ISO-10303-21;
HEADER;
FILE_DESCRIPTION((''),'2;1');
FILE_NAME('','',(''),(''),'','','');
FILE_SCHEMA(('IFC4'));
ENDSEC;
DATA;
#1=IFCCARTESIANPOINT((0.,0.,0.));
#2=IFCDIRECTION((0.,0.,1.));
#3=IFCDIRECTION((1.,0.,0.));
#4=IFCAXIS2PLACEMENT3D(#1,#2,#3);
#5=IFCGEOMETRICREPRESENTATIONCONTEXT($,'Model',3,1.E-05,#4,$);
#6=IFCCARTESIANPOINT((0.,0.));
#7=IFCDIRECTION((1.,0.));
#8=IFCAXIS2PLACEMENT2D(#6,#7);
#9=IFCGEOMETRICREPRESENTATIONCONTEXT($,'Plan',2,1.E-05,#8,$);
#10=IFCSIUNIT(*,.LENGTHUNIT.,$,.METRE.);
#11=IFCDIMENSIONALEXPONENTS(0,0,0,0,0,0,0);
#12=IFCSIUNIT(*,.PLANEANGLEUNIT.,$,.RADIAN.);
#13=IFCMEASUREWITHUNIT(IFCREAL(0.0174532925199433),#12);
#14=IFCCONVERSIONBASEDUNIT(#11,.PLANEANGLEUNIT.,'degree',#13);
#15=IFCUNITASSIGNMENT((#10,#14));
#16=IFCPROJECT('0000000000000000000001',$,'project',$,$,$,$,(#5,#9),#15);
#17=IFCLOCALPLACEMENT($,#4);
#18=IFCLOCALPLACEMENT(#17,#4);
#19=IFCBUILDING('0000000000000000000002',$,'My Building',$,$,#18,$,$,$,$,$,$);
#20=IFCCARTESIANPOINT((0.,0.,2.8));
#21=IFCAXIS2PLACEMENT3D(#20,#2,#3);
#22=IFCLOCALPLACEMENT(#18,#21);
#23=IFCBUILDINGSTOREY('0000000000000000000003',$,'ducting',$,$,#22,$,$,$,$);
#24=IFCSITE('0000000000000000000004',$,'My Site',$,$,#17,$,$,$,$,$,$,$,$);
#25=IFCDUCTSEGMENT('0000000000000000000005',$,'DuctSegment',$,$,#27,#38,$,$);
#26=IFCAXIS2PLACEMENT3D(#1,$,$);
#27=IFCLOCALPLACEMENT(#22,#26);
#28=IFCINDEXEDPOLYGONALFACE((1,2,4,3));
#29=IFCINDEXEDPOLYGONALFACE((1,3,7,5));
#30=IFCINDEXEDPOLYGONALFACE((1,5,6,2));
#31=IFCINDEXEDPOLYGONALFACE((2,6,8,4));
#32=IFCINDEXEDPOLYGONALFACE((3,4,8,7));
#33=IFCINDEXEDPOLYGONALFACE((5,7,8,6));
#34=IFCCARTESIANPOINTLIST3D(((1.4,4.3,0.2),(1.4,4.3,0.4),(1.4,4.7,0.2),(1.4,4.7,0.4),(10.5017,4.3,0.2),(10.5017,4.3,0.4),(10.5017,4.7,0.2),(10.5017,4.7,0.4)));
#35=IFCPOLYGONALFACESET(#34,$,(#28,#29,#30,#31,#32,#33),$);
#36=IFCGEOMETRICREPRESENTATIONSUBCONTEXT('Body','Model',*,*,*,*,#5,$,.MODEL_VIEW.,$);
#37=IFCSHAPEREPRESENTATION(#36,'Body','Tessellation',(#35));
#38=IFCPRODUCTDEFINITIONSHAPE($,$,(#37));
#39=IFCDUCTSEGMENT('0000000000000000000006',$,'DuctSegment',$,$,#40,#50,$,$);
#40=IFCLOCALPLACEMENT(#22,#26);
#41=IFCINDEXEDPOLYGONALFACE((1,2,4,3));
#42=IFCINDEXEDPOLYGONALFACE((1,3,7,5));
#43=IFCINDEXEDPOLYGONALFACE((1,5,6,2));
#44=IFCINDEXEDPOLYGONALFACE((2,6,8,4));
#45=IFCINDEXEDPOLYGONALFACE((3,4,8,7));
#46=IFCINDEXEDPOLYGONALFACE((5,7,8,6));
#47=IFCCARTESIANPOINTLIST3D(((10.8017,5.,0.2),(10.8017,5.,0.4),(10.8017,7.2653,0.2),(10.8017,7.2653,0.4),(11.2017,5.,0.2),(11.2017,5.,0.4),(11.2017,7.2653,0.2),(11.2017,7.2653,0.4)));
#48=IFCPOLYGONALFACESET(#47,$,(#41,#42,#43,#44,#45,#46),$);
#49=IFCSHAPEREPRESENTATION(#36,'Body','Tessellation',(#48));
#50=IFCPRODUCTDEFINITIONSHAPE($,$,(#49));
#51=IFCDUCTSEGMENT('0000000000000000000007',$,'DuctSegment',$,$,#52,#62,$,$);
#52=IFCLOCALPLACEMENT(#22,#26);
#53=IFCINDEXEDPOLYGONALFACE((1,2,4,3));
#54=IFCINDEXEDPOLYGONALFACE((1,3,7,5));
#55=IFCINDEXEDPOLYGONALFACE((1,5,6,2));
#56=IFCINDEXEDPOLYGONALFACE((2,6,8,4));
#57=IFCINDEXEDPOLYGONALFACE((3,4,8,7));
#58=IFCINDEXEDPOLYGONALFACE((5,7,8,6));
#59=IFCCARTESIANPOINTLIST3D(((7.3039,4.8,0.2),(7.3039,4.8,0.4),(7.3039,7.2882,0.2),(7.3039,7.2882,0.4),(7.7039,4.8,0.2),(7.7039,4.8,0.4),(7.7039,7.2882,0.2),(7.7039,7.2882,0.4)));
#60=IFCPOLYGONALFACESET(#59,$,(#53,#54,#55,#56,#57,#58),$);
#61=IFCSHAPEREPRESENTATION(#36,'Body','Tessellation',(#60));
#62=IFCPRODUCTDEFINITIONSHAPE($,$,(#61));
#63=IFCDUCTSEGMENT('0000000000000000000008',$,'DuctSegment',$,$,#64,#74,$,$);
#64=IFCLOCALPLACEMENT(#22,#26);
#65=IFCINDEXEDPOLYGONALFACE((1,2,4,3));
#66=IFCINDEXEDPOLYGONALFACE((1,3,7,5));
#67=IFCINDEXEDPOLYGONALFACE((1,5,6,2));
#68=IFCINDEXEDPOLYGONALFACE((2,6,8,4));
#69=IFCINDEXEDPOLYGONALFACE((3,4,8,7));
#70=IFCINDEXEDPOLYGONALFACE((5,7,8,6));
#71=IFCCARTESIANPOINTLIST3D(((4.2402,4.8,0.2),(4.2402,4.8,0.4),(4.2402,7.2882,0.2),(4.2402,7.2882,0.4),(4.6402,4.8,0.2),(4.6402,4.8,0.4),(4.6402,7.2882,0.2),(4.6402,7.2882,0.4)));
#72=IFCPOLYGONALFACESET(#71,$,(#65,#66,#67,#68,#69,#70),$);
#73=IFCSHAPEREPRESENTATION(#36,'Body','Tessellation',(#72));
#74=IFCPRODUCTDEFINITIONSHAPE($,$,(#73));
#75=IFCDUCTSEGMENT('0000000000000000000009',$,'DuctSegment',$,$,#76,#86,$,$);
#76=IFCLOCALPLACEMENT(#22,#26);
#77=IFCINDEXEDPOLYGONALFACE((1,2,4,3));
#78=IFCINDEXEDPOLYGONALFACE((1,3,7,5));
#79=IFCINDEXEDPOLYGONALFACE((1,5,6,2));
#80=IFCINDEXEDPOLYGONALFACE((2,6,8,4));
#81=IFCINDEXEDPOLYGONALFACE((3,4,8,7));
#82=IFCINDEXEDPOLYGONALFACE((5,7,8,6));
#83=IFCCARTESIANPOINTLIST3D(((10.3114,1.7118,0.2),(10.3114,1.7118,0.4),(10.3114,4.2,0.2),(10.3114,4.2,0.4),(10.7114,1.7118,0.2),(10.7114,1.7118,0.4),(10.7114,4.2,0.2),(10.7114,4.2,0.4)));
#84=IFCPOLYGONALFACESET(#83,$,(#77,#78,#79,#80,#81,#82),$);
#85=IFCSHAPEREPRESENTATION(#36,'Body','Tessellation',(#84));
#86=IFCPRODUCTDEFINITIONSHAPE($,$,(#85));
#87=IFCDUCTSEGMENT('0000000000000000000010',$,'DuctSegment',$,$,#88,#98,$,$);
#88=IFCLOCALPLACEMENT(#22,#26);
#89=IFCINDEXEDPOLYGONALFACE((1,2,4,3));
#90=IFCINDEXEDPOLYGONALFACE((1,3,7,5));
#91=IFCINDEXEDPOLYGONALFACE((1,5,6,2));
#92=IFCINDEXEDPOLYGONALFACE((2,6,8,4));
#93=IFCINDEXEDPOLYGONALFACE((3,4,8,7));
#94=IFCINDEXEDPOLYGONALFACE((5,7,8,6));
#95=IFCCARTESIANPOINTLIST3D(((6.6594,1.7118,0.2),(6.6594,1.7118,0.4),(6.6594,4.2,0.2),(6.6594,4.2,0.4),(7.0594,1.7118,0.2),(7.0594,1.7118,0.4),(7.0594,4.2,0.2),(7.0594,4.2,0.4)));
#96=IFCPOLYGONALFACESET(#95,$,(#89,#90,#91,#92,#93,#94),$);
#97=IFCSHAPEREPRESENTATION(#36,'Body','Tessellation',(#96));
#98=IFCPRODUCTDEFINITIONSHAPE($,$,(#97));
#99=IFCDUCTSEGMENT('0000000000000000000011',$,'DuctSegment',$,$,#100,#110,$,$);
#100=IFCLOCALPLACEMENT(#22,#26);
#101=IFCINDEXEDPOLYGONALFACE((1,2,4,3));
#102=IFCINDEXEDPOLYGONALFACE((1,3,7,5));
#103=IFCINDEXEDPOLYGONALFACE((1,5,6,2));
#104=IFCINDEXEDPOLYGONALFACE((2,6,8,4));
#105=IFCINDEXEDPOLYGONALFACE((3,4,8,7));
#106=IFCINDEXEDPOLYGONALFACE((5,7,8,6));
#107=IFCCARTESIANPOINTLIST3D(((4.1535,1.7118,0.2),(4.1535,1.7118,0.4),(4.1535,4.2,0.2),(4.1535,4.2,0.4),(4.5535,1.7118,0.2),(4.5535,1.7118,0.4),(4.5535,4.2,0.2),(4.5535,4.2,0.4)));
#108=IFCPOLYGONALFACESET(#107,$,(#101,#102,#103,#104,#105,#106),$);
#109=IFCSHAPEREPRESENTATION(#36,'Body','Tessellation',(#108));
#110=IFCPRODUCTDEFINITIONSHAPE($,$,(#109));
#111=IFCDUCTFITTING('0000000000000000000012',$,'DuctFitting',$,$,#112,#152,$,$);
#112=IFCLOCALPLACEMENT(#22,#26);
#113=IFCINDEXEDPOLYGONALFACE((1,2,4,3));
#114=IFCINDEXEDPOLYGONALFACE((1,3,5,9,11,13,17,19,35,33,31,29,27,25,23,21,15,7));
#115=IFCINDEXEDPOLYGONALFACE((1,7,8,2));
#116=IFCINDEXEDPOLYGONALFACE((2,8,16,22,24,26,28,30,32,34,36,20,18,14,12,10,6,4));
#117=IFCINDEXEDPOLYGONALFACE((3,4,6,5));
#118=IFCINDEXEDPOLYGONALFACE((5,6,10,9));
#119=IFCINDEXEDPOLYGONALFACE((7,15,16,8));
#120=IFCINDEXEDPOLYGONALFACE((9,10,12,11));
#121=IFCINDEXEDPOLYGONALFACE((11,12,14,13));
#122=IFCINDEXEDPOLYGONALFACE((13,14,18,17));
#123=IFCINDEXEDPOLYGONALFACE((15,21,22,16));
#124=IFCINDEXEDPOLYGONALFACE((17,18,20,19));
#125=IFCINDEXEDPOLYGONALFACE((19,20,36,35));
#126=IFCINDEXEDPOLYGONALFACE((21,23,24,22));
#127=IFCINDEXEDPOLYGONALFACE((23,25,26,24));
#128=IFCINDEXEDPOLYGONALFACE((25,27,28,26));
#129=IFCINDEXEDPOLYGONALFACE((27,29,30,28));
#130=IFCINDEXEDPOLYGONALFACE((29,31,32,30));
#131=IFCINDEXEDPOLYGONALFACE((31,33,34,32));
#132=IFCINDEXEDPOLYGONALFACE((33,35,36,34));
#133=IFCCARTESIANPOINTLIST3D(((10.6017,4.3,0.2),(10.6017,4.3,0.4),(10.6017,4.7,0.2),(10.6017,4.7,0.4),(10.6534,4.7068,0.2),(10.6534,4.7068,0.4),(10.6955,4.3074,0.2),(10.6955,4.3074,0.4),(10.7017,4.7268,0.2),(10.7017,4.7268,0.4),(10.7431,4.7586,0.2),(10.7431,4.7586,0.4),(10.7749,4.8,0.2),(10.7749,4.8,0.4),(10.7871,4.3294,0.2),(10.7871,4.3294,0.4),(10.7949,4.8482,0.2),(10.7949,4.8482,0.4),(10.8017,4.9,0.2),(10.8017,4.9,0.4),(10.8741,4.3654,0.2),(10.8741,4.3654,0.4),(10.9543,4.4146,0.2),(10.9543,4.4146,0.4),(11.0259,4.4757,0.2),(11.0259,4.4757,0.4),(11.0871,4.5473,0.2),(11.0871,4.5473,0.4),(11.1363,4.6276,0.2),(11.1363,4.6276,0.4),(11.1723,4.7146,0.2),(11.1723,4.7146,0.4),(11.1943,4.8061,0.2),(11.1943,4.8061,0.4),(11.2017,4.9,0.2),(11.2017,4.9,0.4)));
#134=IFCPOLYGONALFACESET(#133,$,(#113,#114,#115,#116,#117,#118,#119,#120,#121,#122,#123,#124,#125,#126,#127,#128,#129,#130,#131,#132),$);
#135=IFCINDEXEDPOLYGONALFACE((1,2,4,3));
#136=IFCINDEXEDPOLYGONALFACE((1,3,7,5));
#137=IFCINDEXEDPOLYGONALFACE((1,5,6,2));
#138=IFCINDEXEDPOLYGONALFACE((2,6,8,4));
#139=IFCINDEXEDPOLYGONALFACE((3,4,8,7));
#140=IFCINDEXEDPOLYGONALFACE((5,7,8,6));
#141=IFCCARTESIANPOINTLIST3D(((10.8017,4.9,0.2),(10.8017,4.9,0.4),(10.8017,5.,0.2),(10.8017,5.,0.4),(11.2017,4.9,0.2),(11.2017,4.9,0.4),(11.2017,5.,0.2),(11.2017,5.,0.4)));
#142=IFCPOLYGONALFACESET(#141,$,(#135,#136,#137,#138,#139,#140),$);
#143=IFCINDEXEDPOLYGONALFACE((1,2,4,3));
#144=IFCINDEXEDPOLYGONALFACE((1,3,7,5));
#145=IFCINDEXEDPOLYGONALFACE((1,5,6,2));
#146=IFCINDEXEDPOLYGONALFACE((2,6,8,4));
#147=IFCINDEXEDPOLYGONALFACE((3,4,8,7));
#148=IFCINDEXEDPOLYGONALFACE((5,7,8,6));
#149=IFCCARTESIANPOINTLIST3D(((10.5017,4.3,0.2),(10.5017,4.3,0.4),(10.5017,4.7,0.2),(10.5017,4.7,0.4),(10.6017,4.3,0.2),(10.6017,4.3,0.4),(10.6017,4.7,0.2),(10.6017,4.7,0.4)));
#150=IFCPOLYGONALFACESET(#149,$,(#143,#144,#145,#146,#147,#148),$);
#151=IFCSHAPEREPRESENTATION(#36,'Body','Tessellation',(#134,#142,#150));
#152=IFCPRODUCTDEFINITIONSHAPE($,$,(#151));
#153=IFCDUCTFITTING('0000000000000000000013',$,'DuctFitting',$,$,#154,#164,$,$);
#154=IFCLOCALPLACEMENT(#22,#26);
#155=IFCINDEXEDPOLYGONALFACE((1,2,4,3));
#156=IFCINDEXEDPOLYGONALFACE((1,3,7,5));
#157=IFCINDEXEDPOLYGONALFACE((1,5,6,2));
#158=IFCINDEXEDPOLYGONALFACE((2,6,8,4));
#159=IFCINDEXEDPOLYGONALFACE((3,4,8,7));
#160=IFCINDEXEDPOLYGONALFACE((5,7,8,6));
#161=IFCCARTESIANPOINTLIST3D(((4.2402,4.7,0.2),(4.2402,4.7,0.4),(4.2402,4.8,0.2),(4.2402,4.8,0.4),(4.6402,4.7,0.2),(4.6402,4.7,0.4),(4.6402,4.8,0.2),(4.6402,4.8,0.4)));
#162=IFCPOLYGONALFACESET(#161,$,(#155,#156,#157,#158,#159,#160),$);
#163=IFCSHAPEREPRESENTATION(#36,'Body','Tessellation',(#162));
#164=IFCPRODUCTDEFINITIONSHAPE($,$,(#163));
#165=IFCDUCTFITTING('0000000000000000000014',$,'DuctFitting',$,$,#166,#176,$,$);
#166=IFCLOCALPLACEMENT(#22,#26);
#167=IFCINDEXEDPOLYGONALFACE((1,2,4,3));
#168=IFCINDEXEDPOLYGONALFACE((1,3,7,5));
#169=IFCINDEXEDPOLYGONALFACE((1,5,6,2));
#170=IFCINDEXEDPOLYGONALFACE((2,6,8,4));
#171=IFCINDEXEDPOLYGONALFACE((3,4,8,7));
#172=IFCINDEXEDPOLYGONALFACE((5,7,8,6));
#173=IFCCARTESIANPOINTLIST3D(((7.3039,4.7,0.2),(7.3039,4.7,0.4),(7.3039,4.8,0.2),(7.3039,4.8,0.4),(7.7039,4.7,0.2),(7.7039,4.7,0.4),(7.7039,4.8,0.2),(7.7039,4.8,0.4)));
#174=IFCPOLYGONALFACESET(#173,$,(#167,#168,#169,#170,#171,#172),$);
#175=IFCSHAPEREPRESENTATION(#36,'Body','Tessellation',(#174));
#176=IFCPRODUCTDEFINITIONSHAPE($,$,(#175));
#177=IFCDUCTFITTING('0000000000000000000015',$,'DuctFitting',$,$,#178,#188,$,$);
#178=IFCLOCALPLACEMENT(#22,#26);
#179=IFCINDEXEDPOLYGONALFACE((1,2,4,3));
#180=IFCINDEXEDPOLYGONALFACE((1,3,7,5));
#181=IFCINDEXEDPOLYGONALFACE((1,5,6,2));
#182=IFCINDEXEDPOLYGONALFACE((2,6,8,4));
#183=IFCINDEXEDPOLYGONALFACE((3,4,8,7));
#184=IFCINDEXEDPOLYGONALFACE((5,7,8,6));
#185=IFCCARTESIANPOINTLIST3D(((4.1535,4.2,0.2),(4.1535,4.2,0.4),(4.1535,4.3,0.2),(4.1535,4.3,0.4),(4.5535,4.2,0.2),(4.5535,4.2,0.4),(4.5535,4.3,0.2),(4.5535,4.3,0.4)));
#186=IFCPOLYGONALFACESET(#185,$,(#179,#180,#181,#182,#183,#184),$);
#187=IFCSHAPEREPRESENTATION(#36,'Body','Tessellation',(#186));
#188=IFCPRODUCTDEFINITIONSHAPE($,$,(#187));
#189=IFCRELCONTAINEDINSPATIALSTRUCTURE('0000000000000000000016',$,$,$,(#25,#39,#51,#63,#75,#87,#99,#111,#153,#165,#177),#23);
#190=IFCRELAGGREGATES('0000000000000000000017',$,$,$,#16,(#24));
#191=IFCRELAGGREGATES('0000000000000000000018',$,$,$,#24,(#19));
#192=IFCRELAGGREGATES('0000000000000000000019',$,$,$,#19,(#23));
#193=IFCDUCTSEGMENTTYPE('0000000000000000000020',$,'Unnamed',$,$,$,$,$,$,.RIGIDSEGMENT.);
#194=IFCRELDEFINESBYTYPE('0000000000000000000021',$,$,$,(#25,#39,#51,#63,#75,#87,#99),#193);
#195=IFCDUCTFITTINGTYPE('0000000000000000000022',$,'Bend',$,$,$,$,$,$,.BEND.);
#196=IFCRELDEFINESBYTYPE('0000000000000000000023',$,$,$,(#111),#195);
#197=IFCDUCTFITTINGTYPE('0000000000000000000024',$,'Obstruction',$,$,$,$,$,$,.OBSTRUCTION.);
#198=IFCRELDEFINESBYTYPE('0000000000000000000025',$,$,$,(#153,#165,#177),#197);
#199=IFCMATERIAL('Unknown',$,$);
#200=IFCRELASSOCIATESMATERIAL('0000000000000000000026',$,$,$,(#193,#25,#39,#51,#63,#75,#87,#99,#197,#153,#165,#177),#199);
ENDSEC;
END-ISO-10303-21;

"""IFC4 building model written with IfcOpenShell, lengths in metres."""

from ifc_helpers import new_model, entity, si_unit, converted_unit, frame, origin_with_axes, origin_2d_with_axis, place, context, subcontext, project, spatial, line, arc, indexed_curve, rectangle, outline, extrude, source, transform, mapped, material, material_profile, profile_set, profile_usage, type_object, type_shapes, element, save


model = new_model("IFC4")

# Units and contexts
model_context = context("Model", 3, precision=1e-05, world=origin_with_axes())
plan_context = context("Plan", 2, precision=1e-05, world=origin_2d_with_axis())
body_context = subcontext(model_context, "Body", "Model", "MODEL_VIEW")
ifc_project = project(units=[si_unit("LENGTHUNIT", "METRE"), converted_unit("PLANEANGLEUNIT", "degree", entity("IfcReal", 0.0174532925199433), si_unit("PLANEANGLEUNIT", "RADIAN"), dimensions=[0, 0, 0, 0, 0, 0, 0])], contexts=[model_context, plan_context])

# Site, building, storey
site_placement = place(None, origin_with_axes())
site = spatial("IfcSite", under=ifc_project, at=site_placement, Name="My Site")
building_placement = place(site_placement, origin_with_axes())
building = spatial("IfcBuilding", under=site, at=building_placement, Name="My Building")
storey_placement = place(building_placement, frame((0.0, 0.0, 2.8), z_axis=(0.0, 0.0, 1.0), x_axis=(1.0, 0.0, 0.0)))
storey = spatial("IfcBuildingStorey", under=building, at=storey_placement, Name="ducting")

# Duct segments
ifc_material = material(Name="Unknown")
ifc_material_profile_1 = material_profile(ifc_material, rectangle(XDim=0.4, YDim=0.2))
ifc_profile_set_1 = profile_set([ifc_material_profile_1])
ifc_profile_usage_1 = profile_usage(ifc_profile_set_1, cardinal=5)
duct_segment_type = type_object("IfcDuctSegmentType", Name="Unnamed", PredefinedType="RIGIDSEGMENT", material=ifc_profile_set_1)
duct_segment_1_placement = place(storey_placement, frame((1.4, 4.5, 0.3), z_axis=(1.0, 0.0, 0.0), x_axis=(0.0, 1.0, 0.0)))
element("IfcDuctSegment", 1, at=duct_segment_1_placement, inside=storey, type_object=duct_segment_type, material=ifc_profile_usage_1, Name="DuctSegment", context=body_context, shape_type="SweptSolid", body=[
    extrude(rectangle(XDim=0.4, YDim=0.2), origin_with_axes(), (0.0, 0.0, 1.0), 9.1017),
])
ifc_profile_usage_2 = profile_usage(ifc_profile_set_1, cardinal=5)
duct_segment_2_placement = place(storey_placement, frame((11.0017, 5.0, 0.3), z_axis=(0.0, 1.0, 0.0), x_axis=(-1.0, 0.0, 0.0)))
element("IfcDuctSegment", 2, at=duct_segment_2_placement, inside=storey, type_object=duct_segment_type, material=ifc_profile_usage_2, Name="DuctSegment", context=body_context, shape_type="SweptSolid", body=[
    extrude(rectangle(XDim=0.4, YDim=0.2), origin_with_axes(), (0.0, 0.0, 1.0), 2.2653),
])
ifc_profile_usage_3 = profile_usage(ifc_profile_set_1, cardinal=5)
duct_segment_3_placement = place(storey_placement, frame((7.5039, 4.8, 0.3), z_axis=(0.0, 1.0, 0.0), x_axis=(-1.0, 0.0, 0.0)))
element("IfcDuctSegment", 3, at=duct_segment_3_placement, inside=storey, type_object=duct_segment_type, material=ifc_profile_usage_3, Name="DuctSegment", context=body_context, shape_type="SweptSolid", body=[
    extrude(rectangle(XDim=0.4, YDim=0.2), origin_with_axes(), (0.0, 0.0, 1.0), 2.4882),
])
ifc_profile_usage_4 = profile_usage(ifc_profile_set_1, cardinal=5)
duct_segment_4_placement = place(storey_placement, frame((4.4402, 4.8, 0.3), z_axis=(0.0, 1.0, 0.0), x_axis=(-1.0, 0.0, 0.0)))
element("IfcDuctSegment", 4, at=duct_segment_4_placement, inside=storey, type_object=duct_segment_type, material=ifc_profile_usage_4, Name="DuctSegment", context=body_context, shape_type="SweptSolid", body=[
    extrude(rectangle(XDim=0.4, YDim=0.2), origin_with_axes(), (0.0, 0.0, 1.0), 2.4882),
])
ifc_profile_usage_5 = profile_usage(ifc_profile_set_1, cardinal=5)
duct_segment_5_placement = place(storey_placement, frame((10.5114, 4.2, 0.3), z_axis=(0.0, -1.0, 0.0), x_axis=(1.0, 0.0, 0.0)))
element("IfcDuctSegment", 5, at=duct_segment_5_placement, inside=storey, type_object=duct_segment_type, material=ifc_profile_usage_5, Name="DuctSegment", context=body_context, shape_type="SweptSolid", body=[
    extrude(rectangle(XDim=0.4, YDim=0.2), origin_with_axes(), (0.0, 0.0, 1.0), 2.4882),
])
ifc_profile_usage_6 = profile_usage(ifc_profile_set_1, cardinal=5)
duct_segment_6_placement = place(storey_placement, frame((6.8594, 4.2, 0.3), z_axis=(0.0, -1.0, 0.0), x_axis=(1.0, 0.0, 0.0)))
element("IfcDuctSegment", 6, at=duct_segment_6_placement, inside=storey, type_object=duct_segment_type, material=ifc_profile_usage_6, Name="DuctSegment", context=body_context, shape_type="SweptSolid", body=[
    extrude(rectangle(XDim=0.4, YDim=0.2), origin_with_axes(), (0.0, 0.0, 1.0), 2.4882),
])
ifc_profile_usage_7 = profile_usage(ifc_profile_set_1, cardinal=5)
duct_segment_7_placement = place(storey_placement, frame((4.3535, 4.2, 0.3), z_axis=(0.0, -1.0, 0.0), x_axis=(1.0, 0.0, 0.0)))
element("IfcDuctSegment", 7, at=duct_segment_7_placement, inside=storey, type_object=duct_segment_type, material=ifc_profile_usage_7, Name="DuctSegment", context=body_context, shape_type="SweptSolid", body=[
    extrude(rectangle(XDim=0.4, YDim=0.2), origin_with_axes(), (0.0, 0.0, 1.0), 2.4882),
])

# Duct fittings
duct_fitting_type_1 = type_object("IfcDuctFittingType", Name="Bend", PredefinedType="BEND")
shared_shape = source(origin_with_axes(), body_context, "Body", "SweptSolid", [
    extrude(outline(indexed_curve([(0.2, 0.0), (0.2586, -0.1414), (0.4, -0.2), (0.4, -0.6), (-0.0243, -0.4243), (-0.2, 0.0)], segments=[arc(1, 2, 3), line(3, 4), arc(4, 5, 6), line(6, 1)])), frame((0.0, -0.1, -0.1), z_axis=(0.0, -1.0, 0.0), x_axis=(1.0, 0.0, 0.0)), (0.0, 0.0, -1.0), 0.2),
    extrude(rectangle(XDim=0.4, YDim=0.2), origin_with_axes(), (0.0, 0.0, -1.0), 0.1),
    extrude(rectangle(XDim=0.4, YDim=0.2), frame((0.4, 0.0, -0.5), z_axis=(1.0, 0.0, 0.0), x_axis=(0.0, 0.0, 1.0)), (0.0, 0.0, 1.0), 0.1),
])
type_shapes(duct_fitting_type_1, [shared_shape])
duct_fitting_1_placement = place(storey_placement, frame((11.0017, 5.0, 0.3), z_axis=(0.0, 1.0, 0.0), x_axis=(-1.0, 0.0, 0.0)))
element("IfcDuctFitting", 8, at=duct_fitting_1_placement, inside=storey, type_object=duct_fitting_type_1, Name="DuctFitting", context=body_context, shape_type="MappedRepresentation", body=[
    mapped(shared_shape, transform((0.0, 0.0, 0.0), x_axis=(1.0, 0.0, 0.0), y_axis=(0.0, 1.0, 0.0), z_axis=(0.0, 0.0, 1.0), scale=1.0)),
])
ifc_material_profile_2 = material_profile(ifc_material, rectangle(XDim=0.4, YDim=0.2))
ifc_profile_set_2 = profile_set([ifc_material_profile_2])
ifc_profile_usage_8 = profile_usage(ifc_profile_set_2, cardinal=5)
duct_fitting_type_2 = type_object("IfcDuctFittingType", Name="Obstruction", PredefinedType="OBSTRUCTION", material=ifc_profile_set_2)
duct_fitting_2_placement = place(storey_placement, frame((4.4402, 4.7, 0.3), z_axis=(0.0, 1.0, 0.0), x_axis=(-1.0, 0.0, 0.0)))
element("IfcDuctFitting", 9, at=duct_fitting_2_placement, inside=storey, type_object=duct_fitting_type_2, material=ifc_profile_usage_8, Name="DuctFitting", context=body_context, shape_type="SweptSolid", body=[
    extrude(rectangle(XDim=0.4, YDim=0.2), origin_with_axes(), (0.0, 0.0, 1.0), 0.1),
])
ifc_profile_usage_9 = profile_usage(ifc_profile_set_2, cardinal=5)
duct_fitting_3_placement = place(storey_placement, frame((7.5039, 4.7, 0.3), z_axis=(0.0, 1.0, 0.0), x_axis=(-1.0, 0.0, 0.0)))
element("IfcDuctFitting", 10, at=duct_fitting_3_placement, inside=storey, type_object=duct_fitting_type_2, material=ifc_profile_usage_9, Name="DuctFitting", context=body_context, shape_type="SweptSolid", body=[
    extrude(rectangle(XDim=0.4, YDim=0.2), origin_with_axes(), (0.0, 0.0, 1.0), 0.1),
])
ifc_profile_usage_10 = profile_usage(ifc_profile_set_2, cardinal=5)
duct_fitting_4_placement = place(storey_placement, frame((4.3535, 4.3, 0.3), z_axis=(0.0, -1.0, 0.0), x_axis=(1.0, 0.0, 0.0)))
element("IfcDuctFitting", 11, at=duct_fitting_4_placement, inside=storey, type_object=duct_fitting_type_2, material=ifc_profile_usage_10, Name="DuctFitting", context=body_context, shape_type="SweptSolid", body=[
    extrude(rectangle(XDim=0.4, YDim=0.2), origin_with_axes(), (0.0, 0.0, 1.0), 0.1),
])

save(model, "model.ifc")
